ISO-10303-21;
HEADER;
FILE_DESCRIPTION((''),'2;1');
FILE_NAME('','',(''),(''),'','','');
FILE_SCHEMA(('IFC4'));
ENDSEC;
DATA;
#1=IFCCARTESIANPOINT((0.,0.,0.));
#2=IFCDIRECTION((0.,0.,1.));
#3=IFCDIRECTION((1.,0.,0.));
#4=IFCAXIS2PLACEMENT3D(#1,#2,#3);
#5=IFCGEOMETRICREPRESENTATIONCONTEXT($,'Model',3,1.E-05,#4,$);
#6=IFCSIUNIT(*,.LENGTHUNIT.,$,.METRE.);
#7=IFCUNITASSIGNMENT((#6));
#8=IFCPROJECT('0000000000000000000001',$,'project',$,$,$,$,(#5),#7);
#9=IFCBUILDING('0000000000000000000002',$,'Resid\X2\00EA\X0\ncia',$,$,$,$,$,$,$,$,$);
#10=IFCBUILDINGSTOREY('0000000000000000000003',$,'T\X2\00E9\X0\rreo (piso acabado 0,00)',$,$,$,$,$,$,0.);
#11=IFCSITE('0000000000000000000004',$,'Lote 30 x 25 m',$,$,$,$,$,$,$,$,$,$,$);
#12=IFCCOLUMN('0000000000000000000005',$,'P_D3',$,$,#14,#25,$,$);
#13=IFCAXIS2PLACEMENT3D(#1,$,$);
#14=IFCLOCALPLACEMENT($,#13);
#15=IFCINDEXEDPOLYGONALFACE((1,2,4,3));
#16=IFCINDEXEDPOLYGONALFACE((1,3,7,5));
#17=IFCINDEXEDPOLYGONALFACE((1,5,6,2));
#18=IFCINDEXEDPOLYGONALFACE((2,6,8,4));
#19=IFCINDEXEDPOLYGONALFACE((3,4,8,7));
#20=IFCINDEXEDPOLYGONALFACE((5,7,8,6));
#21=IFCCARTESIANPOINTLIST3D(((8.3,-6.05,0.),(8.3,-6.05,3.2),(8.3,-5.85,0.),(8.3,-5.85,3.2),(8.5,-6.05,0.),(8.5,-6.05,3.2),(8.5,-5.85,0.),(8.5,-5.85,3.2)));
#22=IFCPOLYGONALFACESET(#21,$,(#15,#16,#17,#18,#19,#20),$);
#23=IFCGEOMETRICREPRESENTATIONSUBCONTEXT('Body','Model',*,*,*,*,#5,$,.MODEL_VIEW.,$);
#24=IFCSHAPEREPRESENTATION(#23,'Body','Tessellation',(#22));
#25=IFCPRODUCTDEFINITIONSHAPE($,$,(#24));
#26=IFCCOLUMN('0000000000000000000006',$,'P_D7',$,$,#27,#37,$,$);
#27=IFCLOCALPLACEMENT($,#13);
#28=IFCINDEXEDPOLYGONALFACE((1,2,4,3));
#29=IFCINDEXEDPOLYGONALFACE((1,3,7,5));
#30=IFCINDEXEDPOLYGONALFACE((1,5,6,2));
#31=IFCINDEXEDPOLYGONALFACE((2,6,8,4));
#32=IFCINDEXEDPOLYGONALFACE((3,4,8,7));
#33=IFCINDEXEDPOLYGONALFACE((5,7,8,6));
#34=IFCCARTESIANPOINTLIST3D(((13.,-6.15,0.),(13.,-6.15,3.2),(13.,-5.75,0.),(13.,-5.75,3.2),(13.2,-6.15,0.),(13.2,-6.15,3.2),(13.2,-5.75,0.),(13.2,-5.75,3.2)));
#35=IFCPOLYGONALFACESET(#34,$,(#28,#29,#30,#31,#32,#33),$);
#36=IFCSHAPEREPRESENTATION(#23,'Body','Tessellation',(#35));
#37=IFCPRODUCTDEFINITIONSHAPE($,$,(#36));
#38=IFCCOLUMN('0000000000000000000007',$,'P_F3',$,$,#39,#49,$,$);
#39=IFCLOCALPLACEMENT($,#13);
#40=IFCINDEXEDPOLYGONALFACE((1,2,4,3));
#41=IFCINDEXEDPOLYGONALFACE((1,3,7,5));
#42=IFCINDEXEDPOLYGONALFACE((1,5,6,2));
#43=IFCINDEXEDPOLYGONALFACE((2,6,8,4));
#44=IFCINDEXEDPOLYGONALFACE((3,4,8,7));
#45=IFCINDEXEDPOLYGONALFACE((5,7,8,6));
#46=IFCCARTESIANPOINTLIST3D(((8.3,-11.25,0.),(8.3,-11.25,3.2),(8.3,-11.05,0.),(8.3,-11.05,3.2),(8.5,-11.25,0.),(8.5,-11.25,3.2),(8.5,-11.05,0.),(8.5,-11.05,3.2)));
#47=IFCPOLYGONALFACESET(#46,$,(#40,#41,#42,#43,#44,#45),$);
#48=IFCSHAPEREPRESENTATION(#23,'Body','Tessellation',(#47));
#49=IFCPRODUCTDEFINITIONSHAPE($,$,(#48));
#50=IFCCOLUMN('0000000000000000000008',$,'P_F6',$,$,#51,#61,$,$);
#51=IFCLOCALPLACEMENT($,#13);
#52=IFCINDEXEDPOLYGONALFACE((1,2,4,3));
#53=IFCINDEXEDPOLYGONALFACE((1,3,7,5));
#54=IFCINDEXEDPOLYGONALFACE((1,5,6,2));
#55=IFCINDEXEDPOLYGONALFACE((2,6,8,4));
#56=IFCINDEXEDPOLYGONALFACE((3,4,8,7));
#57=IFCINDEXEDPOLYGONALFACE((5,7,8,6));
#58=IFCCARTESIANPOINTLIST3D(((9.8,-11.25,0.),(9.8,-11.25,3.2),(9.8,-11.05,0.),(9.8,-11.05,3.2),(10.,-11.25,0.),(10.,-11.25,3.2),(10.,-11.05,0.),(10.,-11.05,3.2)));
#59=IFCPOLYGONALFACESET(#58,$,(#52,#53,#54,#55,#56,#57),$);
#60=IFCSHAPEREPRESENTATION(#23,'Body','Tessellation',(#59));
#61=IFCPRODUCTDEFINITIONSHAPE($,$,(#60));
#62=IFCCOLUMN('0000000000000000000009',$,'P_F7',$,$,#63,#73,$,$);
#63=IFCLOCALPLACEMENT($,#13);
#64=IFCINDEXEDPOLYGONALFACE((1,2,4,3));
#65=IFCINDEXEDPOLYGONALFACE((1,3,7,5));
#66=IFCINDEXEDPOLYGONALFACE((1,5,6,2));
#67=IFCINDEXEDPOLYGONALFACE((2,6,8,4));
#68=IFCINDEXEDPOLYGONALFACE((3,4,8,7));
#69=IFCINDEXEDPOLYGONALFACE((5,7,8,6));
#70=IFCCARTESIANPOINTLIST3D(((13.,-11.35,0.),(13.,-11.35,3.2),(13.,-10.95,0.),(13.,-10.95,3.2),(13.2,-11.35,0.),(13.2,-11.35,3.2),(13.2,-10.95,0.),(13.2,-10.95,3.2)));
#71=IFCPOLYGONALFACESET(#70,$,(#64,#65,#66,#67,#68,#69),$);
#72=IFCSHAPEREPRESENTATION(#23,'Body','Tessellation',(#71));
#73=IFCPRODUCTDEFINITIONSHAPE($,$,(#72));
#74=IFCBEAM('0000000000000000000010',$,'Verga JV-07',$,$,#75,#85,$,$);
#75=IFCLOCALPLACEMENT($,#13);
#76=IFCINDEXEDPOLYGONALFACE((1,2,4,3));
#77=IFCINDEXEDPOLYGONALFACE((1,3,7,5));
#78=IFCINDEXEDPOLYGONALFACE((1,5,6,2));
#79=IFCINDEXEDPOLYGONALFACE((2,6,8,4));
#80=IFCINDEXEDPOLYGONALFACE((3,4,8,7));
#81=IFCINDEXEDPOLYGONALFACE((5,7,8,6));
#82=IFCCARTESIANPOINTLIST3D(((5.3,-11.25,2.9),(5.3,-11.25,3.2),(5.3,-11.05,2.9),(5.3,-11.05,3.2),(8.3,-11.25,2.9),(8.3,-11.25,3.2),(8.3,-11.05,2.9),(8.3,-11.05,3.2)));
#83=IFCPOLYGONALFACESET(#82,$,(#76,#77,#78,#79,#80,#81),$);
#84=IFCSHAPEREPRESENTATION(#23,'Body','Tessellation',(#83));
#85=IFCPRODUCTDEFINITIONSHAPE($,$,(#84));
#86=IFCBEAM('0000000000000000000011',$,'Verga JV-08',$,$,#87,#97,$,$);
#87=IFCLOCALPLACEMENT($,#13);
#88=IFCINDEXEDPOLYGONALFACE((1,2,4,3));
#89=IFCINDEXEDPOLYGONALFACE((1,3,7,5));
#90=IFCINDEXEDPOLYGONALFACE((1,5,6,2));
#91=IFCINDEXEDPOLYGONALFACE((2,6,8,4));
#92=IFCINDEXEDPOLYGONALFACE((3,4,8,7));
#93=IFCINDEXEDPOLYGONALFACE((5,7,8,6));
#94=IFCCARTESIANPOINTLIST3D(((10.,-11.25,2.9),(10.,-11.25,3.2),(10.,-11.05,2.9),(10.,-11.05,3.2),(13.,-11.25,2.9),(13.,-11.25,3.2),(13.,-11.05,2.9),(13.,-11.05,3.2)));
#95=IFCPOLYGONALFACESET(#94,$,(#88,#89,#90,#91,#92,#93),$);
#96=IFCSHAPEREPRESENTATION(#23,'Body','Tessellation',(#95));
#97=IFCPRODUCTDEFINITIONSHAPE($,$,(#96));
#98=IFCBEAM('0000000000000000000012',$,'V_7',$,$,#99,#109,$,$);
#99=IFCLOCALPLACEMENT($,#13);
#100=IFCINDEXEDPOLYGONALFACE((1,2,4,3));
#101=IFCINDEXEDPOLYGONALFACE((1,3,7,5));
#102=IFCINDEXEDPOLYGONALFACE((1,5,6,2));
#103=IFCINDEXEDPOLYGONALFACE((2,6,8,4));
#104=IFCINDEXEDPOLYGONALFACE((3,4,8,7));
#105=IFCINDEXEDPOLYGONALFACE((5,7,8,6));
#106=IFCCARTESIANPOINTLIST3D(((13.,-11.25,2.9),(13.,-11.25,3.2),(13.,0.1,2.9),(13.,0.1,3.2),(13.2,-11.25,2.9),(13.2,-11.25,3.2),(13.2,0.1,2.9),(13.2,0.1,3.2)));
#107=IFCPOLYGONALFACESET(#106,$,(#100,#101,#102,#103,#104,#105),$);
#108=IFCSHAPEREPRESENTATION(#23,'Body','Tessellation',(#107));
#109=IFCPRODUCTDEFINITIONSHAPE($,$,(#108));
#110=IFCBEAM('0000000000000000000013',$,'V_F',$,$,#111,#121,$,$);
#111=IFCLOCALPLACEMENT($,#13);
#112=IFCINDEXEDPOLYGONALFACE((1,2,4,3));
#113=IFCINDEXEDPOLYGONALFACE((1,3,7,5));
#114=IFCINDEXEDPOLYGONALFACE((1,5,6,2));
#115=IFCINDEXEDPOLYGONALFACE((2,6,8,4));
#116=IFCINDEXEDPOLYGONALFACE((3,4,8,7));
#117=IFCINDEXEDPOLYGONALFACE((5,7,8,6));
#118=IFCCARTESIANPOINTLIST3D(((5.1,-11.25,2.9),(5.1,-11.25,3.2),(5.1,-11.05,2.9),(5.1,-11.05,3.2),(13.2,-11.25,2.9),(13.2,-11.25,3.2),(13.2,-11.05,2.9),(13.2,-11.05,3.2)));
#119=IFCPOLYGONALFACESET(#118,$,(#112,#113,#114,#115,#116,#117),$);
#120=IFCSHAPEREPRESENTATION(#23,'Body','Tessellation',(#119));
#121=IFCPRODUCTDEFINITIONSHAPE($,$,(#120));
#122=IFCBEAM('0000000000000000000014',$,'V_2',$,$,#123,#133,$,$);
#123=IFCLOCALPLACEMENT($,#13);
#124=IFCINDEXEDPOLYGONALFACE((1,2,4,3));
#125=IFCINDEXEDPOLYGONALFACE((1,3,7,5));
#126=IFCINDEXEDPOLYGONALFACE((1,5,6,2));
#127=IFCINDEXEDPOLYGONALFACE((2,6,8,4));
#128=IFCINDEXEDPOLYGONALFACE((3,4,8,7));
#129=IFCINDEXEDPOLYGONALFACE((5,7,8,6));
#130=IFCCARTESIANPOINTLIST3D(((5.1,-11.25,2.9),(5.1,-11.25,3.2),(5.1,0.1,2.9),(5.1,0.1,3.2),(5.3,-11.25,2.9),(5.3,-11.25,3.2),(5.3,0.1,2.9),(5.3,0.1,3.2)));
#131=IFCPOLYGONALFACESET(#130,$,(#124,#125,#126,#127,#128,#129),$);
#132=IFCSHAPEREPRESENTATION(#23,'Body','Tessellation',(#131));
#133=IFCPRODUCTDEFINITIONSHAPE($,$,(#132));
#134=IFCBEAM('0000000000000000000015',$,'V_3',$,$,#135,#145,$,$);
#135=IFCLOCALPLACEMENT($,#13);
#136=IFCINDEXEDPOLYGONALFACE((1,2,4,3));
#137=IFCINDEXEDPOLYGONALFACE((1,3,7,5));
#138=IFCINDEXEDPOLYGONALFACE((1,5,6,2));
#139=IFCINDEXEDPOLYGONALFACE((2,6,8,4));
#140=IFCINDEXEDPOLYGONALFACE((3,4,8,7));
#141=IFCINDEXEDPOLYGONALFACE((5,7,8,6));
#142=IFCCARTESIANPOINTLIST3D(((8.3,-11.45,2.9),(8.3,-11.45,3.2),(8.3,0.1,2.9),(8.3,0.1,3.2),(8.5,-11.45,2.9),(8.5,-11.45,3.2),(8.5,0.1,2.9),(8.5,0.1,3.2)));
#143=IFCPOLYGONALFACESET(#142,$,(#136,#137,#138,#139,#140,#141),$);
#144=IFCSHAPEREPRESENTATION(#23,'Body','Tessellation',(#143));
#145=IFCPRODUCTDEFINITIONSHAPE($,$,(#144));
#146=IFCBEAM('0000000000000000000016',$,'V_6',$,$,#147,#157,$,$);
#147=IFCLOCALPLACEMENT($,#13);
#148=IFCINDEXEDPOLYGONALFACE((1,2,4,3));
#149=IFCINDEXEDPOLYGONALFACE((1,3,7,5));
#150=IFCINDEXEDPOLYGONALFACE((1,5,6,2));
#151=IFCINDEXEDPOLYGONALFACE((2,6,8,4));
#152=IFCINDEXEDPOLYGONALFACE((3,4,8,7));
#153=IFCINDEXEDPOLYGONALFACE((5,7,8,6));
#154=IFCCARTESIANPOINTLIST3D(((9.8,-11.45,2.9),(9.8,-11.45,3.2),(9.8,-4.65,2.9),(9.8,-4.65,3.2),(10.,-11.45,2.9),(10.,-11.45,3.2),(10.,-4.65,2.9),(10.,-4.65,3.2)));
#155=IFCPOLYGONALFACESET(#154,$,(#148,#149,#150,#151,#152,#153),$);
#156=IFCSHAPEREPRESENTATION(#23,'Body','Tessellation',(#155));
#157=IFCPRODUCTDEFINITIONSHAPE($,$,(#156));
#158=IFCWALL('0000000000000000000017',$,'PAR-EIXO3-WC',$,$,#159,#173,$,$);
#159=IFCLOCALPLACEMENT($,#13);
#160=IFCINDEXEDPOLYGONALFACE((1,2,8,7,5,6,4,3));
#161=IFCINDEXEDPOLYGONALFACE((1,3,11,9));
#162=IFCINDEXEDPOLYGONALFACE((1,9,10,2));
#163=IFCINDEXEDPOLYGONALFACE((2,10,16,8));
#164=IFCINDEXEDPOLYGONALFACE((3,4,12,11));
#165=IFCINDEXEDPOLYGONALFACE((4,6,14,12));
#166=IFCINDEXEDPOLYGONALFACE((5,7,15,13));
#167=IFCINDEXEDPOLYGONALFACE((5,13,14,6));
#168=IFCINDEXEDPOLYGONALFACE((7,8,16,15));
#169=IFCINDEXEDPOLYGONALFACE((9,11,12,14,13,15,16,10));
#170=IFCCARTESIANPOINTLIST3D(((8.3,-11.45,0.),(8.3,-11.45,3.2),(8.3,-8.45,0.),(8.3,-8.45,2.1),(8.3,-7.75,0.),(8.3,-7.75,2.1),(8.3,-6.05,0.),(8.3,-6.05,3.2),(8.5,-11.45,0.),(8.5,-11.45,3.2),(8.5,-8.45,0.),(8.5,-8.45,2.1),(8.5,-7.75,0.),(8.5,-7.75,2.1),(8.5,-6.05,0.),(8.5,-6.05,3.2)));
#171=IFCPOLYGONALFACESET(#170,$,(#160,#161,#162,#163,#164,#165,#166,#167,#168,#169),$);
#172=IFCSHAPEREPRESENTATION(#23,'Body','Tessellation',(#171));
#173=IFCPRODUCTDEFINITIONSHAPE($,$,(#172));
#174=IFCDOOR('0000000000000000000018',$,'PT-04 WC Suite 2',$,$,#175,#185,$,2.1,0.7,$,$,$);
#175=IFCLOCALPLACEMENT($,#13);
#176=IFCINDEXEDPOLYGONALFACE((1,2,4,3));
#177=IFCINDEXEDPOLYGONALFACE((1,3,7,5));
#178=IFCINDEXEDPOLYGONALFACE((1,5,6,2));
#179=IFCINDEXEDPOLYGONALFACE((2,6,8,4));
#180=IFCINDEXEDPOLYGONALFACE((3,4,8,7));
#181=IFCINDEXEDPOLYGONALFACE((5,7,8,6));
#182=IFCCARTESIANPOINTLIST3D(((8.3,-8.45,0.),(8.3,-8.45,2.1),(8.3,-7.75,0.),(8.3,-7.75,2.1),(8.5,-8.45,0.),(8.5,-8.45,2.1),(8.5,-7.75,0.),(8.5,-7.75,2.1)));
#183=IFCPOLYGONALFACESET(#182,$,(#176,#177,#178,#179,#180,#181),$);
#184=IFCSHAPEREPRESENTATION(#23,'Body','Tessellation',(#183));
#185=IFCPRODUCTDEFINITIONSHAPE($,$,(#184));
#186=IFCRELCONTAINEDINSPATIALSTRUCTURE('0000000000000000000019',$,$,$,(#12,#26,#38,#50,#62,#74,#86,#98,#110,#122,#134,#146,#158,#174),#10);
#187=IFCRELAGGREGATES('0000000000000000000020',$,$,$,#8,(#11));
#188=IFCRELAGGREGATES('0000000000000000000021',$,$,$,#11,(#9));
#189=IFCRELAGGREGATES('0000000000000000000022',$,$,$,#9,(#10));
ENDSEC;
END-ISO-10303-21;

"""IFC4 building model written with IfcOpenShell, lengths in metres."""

from ifc_helpers import new_model, si_unit, frame, origin_with_axes, place, context, subcontext, project, spatial, line, indexed_curve, outline, extrude, element, fill, save


model = new_model("IFC4")

# Units and contexts
model_context = context("Model", 3, precision=1e-05, world=origin_with_axes())
body_context = subcontext(model_context, "Body", "Model", "MODEL_VIEW")
ifc_project = project(units=[si_unit("LENGTHUNIT", "METRE")], contexts=[model_context])

# Site, building, storey
site = spatial("IfcSite", under=ifc_project, Name="Lote 30 x 25 m")
building = spatial("IfcBuilding", under=site, Name="Residência")
storey = spatial("IfcBuildingStorey", under=building, Name="Térreo (piso acabado 0,00)", Elevation=0.0)

# Columns
column_1_placement = place(None, frame((8.3, -6.05, 0.0), z_axis=(0.0, 0.0, 1.0), x_axis=(1.0, 0.0, 0.0)))
element("IfcColumn", 1, at=column_1_placement, inside=storey, Name="P_D3", context=body_context, shape_type="SweptSolid", body=[
    extrude(outline(indexed_curve([(0.0, 0.0), (0.2, 0.0), (0.2, 0.2), (0.0, 0.2)], segments=[line(1, 2, 3, 4, 1)])), origin_with_axes(), (0.0, 0.0, 1.0), 3.2),
])
column_2_placement = place(None, frame((13.0, -6.15, 0.0), z_axis=(0.0, 0.0, 1.0), x_axis=(1.0, 0.0, 0.0)))
element("IfcColumn", 2, at=column_2_placement, inside=storey, Name="P_D7", context=body_context, shape_type="SweptSolid", body=[
    extrude(outline(indexed_curve([(0.0, 0.0), (0.2, 0.0), (0.2, 0.4), (0.0, 0.4)], segments=[line(1, 2, 3, 4, 1)])), origin_with_axes(), (0.0, 0.0, 1.0), 3.2),
])
for number, where, z_axis, x_axis, name in (
    (3, (8.3, -11.25, 0.0), (0.0, 0.0, 1.0), (1.0, 0.0, 0.0), "P_F3"),
    (4, (9.8, -11.25, 0.0), (0.0, 0.0, 1.0), (1.0, 0.0, 0.0), "P_F6"),
):
    element("IfcColumn", number, at=place(None, frame(where, z_axis=z_axis, x_axis=x_axis)), inside=storey, Name=name, context=body_context, shape_type="SweptSolid", body=[
        extrude(outline(indexed_curve([(0.0, 0.0), (0.2, 0.0), (0.2, 0.2), (0.0, 0.2)], segments=[line(1, 2, 3, 4, 1)])), origin_with_axes(), (0.0, 0.0, 1.0), 3.2),
    ])
column_3_placement = place(None, frame((13.0, -11.35, 0.0), z_axis=(0.0, 0.0, 1.0), x_axis=(1.0, 0.0, 0.0)))
element("IfcColumn", 5, at=column_3_placement, inside=storey, Name="P_F7", context=body_context, shape_type="SweptSolid", body=[
    extrude(outline(indexed_curve([(0.0, 0.0), (0.2, 0.0), (0.2, 0.4), (0.0, 0.4)], segments=[line(1, 2, 3, 4, 1)])), origin_with_axes(), (0.0, 0.0, 1.0), 3.2),
])

# Beams
for number, where, z_axis, x_axis, name in (
    (6, (5.3, -11.25, 2.9), (0.0, 0.0, 1.0), (1.0, 0.0, 0.0), "Verga JV-07"),
    (7, (10.0, -11.25, 2.9), (0.0, 0.0, 1.0), (1.0, 0.0, 0.0), "Verga JV-08"),
):
    element("IfcBeam", number, at=place(None, frame(where, z_axis=z_axis, x_axis=x_axis)), inside=storey, Name=name, context=body_context, shape_type="SweptSolid", body=[
        extrude(outline(indexed_curve([(0.0, 0.0), (3.0, 0.0), (3.0, 0.2), (0.0, 0.2)], segments=[line(1, 2, 3, 4, 1)])), origin_with_axes(), (0.0, 0.0, 1.0), 0.3),
    ])
beam_1_placement = place(None, frame((13.0, -11.25, 2.9), z_axis=(0.0, 0.0, 1.0), x_axis=(1.0, 0.0, 0.0)))
element("IfcBeam", 8, at=beam_1_placement, inside=storey, Name="V_7", context=body_context, shape_type="SweptSolid", body=[
    extrude(outline(indexed_curve([(0.0, 0.0), (0.2, 0.0), (0.2, 11.35), (0.0, 11.35)], segments=[line(1, 2, 3, 4, 1)])), origin_with_axes(), (0.0, 0.0, 1.0), 0.3),
])
beam_2_placement = place(None, frame((5.1, -11.25, 2.9), z_axis=(0.0, 0.0, 1.0), x_axis=(1.0, 0.0, 0.0)))
element("IfcBeam", 9, at=beam_2_placement, inside=storey, Name="V_F", context=body_context, shape_type="SweptSolid", body=[
    extrude(outline(indexed_curve([(0.0, 0.0), (8.1, 0.0), (8.1, 0.2), (0.0, 0.2)], segments=[line(1, 2, 3, 4, 1)])), origin_with_axes(), (0.0, 0.0, 1.0), 0.3),
])
beam_3_placement = place(None, frame((5.1, -11.25, 2.9), z_axis=(0.0, 0.0, 1.0), x_axis=(1.0, 0.0, 0.0)))
element("IfcBeam", 10, at=beam_3_placement, inside=storey, Name="V_2", context=body_context, shape_type="SweptSolid", body=[
    extrude(outline(indexed_curve([(0.0, 0.0), (0.2, 0.0), (0.2, 11.35), (0.0, 11.35)], segments=[line(1, 2, 3, 4, 1)])), origin_with_axes(), (0.0, 0.0, 1.0), 0.3),
])
beam_4_placement = place(None, frame((8.3, -11.45, 2.9), z_axis=(0.0, 0.0, 1.0), x_axis=(1.0, 0.0, 0.0)))
element("IfcBeam", 11, at=beam_4_placement, inside=storey, Name="V_3", context=body_context, shape_type="SweptSolid", body=[
    extrude(outline(indexed_curve([(0.0, 0.0), (0.2, 0.0), (0.2, 11.55), (0.0, 11.55)], segments=[line(1, 2, 3, 4, 1)])), origin_with_axes(), (0.0, 0.0, 1.0), 0.3),
])
beam_5_placement = place(None, frame((9.8, -11.45, 2.9), z_axis=(0.0, 0.0, 1.0), x_axis=(1.0, 0.0, 0.0)))
element("IfcBeam", 12, at=beam_5_placement, inside=storey, Name="V_6", context=body_context, shape_type="SweptSolid", body=[
    extrude(outline(indexed_curve([(0.0, 0.0), (0.2, 0.0), (0.2, 6.8), (0.0, 6.8)], segments=[line(1, 2, 3, 4, 1)])), origin_with_axes(), (0.0, 0.0, 1.0), 0.3),
])

# Wall, opening, door
wall_1_placement = place(None, frame((8.3, -11.45, 0.0), z_axis=(0.0, 0.0, 1.0), x_axis=(1.0, 0.0, 0.0)))
wall_1 = element("IfcWall", 13, at=wall_1_placement, inside=storey, Name="PAR-EIXO3-WC", context=body_context, shape_type="SweptSolid", body=[
    extrude(outline(indexed_curve([(0.0, 0.0), (0.2, 0.0), (0.2, 5.4), (0.0, 5.4)], segments=[line(1, 2, 3, 4, 1)])), origin_with_axes(), (0.0, 0.0, 1.0), 3.2),
])
opening_1_placement = place(wall_1_placement, frame((0.0, 3.0, 0.0), z_axis=(0.0, 0.0, 1.0), x_axis=(1.0, 0.0, 0.0)))
opening_1 = element("IfcOpeningElement", 14, at=opening_1_placement, cuts=wall_1, context=body_context, shape_type="SweptSolid", body=[
    extrude(outline(indexed_curve([(0.0, 0.0), (0.2, 0.0), (0.2, 0.7), (0.0, 0.7)], segments=[line(1, 2, 3, 4, 1)])), origin_with_axes(), (0.0, 0.0, 1.0), 2.1),
])
door_1_placement = place(None, frame((8.3, -8.45, 0.0), z_axis=(0.0, 0.0, 1.0), x_axis=(1.0, 0.0, 0.0)))
door_1 = element("IfcDoor", 15, at=door_1_placement, inside=storey, Name="PT-04 WC Suite 2", OverallHeight=2.1, OverallWidth=0.7, context=body_context, shape_type="SweptSolid", body=[
    extrude(outline(indexed_curve([(0.0, 0.0), (0.2, 0.0), (0.2, 0.7), (0.0, 0.7)], segments=[line(1, 2, 3, 4, 1)])), origin_with_axes(), (0.0, 0.0, 1.0), 2.1),
])
fill(opening_1, door_1)

save(model, "model.ifc")
